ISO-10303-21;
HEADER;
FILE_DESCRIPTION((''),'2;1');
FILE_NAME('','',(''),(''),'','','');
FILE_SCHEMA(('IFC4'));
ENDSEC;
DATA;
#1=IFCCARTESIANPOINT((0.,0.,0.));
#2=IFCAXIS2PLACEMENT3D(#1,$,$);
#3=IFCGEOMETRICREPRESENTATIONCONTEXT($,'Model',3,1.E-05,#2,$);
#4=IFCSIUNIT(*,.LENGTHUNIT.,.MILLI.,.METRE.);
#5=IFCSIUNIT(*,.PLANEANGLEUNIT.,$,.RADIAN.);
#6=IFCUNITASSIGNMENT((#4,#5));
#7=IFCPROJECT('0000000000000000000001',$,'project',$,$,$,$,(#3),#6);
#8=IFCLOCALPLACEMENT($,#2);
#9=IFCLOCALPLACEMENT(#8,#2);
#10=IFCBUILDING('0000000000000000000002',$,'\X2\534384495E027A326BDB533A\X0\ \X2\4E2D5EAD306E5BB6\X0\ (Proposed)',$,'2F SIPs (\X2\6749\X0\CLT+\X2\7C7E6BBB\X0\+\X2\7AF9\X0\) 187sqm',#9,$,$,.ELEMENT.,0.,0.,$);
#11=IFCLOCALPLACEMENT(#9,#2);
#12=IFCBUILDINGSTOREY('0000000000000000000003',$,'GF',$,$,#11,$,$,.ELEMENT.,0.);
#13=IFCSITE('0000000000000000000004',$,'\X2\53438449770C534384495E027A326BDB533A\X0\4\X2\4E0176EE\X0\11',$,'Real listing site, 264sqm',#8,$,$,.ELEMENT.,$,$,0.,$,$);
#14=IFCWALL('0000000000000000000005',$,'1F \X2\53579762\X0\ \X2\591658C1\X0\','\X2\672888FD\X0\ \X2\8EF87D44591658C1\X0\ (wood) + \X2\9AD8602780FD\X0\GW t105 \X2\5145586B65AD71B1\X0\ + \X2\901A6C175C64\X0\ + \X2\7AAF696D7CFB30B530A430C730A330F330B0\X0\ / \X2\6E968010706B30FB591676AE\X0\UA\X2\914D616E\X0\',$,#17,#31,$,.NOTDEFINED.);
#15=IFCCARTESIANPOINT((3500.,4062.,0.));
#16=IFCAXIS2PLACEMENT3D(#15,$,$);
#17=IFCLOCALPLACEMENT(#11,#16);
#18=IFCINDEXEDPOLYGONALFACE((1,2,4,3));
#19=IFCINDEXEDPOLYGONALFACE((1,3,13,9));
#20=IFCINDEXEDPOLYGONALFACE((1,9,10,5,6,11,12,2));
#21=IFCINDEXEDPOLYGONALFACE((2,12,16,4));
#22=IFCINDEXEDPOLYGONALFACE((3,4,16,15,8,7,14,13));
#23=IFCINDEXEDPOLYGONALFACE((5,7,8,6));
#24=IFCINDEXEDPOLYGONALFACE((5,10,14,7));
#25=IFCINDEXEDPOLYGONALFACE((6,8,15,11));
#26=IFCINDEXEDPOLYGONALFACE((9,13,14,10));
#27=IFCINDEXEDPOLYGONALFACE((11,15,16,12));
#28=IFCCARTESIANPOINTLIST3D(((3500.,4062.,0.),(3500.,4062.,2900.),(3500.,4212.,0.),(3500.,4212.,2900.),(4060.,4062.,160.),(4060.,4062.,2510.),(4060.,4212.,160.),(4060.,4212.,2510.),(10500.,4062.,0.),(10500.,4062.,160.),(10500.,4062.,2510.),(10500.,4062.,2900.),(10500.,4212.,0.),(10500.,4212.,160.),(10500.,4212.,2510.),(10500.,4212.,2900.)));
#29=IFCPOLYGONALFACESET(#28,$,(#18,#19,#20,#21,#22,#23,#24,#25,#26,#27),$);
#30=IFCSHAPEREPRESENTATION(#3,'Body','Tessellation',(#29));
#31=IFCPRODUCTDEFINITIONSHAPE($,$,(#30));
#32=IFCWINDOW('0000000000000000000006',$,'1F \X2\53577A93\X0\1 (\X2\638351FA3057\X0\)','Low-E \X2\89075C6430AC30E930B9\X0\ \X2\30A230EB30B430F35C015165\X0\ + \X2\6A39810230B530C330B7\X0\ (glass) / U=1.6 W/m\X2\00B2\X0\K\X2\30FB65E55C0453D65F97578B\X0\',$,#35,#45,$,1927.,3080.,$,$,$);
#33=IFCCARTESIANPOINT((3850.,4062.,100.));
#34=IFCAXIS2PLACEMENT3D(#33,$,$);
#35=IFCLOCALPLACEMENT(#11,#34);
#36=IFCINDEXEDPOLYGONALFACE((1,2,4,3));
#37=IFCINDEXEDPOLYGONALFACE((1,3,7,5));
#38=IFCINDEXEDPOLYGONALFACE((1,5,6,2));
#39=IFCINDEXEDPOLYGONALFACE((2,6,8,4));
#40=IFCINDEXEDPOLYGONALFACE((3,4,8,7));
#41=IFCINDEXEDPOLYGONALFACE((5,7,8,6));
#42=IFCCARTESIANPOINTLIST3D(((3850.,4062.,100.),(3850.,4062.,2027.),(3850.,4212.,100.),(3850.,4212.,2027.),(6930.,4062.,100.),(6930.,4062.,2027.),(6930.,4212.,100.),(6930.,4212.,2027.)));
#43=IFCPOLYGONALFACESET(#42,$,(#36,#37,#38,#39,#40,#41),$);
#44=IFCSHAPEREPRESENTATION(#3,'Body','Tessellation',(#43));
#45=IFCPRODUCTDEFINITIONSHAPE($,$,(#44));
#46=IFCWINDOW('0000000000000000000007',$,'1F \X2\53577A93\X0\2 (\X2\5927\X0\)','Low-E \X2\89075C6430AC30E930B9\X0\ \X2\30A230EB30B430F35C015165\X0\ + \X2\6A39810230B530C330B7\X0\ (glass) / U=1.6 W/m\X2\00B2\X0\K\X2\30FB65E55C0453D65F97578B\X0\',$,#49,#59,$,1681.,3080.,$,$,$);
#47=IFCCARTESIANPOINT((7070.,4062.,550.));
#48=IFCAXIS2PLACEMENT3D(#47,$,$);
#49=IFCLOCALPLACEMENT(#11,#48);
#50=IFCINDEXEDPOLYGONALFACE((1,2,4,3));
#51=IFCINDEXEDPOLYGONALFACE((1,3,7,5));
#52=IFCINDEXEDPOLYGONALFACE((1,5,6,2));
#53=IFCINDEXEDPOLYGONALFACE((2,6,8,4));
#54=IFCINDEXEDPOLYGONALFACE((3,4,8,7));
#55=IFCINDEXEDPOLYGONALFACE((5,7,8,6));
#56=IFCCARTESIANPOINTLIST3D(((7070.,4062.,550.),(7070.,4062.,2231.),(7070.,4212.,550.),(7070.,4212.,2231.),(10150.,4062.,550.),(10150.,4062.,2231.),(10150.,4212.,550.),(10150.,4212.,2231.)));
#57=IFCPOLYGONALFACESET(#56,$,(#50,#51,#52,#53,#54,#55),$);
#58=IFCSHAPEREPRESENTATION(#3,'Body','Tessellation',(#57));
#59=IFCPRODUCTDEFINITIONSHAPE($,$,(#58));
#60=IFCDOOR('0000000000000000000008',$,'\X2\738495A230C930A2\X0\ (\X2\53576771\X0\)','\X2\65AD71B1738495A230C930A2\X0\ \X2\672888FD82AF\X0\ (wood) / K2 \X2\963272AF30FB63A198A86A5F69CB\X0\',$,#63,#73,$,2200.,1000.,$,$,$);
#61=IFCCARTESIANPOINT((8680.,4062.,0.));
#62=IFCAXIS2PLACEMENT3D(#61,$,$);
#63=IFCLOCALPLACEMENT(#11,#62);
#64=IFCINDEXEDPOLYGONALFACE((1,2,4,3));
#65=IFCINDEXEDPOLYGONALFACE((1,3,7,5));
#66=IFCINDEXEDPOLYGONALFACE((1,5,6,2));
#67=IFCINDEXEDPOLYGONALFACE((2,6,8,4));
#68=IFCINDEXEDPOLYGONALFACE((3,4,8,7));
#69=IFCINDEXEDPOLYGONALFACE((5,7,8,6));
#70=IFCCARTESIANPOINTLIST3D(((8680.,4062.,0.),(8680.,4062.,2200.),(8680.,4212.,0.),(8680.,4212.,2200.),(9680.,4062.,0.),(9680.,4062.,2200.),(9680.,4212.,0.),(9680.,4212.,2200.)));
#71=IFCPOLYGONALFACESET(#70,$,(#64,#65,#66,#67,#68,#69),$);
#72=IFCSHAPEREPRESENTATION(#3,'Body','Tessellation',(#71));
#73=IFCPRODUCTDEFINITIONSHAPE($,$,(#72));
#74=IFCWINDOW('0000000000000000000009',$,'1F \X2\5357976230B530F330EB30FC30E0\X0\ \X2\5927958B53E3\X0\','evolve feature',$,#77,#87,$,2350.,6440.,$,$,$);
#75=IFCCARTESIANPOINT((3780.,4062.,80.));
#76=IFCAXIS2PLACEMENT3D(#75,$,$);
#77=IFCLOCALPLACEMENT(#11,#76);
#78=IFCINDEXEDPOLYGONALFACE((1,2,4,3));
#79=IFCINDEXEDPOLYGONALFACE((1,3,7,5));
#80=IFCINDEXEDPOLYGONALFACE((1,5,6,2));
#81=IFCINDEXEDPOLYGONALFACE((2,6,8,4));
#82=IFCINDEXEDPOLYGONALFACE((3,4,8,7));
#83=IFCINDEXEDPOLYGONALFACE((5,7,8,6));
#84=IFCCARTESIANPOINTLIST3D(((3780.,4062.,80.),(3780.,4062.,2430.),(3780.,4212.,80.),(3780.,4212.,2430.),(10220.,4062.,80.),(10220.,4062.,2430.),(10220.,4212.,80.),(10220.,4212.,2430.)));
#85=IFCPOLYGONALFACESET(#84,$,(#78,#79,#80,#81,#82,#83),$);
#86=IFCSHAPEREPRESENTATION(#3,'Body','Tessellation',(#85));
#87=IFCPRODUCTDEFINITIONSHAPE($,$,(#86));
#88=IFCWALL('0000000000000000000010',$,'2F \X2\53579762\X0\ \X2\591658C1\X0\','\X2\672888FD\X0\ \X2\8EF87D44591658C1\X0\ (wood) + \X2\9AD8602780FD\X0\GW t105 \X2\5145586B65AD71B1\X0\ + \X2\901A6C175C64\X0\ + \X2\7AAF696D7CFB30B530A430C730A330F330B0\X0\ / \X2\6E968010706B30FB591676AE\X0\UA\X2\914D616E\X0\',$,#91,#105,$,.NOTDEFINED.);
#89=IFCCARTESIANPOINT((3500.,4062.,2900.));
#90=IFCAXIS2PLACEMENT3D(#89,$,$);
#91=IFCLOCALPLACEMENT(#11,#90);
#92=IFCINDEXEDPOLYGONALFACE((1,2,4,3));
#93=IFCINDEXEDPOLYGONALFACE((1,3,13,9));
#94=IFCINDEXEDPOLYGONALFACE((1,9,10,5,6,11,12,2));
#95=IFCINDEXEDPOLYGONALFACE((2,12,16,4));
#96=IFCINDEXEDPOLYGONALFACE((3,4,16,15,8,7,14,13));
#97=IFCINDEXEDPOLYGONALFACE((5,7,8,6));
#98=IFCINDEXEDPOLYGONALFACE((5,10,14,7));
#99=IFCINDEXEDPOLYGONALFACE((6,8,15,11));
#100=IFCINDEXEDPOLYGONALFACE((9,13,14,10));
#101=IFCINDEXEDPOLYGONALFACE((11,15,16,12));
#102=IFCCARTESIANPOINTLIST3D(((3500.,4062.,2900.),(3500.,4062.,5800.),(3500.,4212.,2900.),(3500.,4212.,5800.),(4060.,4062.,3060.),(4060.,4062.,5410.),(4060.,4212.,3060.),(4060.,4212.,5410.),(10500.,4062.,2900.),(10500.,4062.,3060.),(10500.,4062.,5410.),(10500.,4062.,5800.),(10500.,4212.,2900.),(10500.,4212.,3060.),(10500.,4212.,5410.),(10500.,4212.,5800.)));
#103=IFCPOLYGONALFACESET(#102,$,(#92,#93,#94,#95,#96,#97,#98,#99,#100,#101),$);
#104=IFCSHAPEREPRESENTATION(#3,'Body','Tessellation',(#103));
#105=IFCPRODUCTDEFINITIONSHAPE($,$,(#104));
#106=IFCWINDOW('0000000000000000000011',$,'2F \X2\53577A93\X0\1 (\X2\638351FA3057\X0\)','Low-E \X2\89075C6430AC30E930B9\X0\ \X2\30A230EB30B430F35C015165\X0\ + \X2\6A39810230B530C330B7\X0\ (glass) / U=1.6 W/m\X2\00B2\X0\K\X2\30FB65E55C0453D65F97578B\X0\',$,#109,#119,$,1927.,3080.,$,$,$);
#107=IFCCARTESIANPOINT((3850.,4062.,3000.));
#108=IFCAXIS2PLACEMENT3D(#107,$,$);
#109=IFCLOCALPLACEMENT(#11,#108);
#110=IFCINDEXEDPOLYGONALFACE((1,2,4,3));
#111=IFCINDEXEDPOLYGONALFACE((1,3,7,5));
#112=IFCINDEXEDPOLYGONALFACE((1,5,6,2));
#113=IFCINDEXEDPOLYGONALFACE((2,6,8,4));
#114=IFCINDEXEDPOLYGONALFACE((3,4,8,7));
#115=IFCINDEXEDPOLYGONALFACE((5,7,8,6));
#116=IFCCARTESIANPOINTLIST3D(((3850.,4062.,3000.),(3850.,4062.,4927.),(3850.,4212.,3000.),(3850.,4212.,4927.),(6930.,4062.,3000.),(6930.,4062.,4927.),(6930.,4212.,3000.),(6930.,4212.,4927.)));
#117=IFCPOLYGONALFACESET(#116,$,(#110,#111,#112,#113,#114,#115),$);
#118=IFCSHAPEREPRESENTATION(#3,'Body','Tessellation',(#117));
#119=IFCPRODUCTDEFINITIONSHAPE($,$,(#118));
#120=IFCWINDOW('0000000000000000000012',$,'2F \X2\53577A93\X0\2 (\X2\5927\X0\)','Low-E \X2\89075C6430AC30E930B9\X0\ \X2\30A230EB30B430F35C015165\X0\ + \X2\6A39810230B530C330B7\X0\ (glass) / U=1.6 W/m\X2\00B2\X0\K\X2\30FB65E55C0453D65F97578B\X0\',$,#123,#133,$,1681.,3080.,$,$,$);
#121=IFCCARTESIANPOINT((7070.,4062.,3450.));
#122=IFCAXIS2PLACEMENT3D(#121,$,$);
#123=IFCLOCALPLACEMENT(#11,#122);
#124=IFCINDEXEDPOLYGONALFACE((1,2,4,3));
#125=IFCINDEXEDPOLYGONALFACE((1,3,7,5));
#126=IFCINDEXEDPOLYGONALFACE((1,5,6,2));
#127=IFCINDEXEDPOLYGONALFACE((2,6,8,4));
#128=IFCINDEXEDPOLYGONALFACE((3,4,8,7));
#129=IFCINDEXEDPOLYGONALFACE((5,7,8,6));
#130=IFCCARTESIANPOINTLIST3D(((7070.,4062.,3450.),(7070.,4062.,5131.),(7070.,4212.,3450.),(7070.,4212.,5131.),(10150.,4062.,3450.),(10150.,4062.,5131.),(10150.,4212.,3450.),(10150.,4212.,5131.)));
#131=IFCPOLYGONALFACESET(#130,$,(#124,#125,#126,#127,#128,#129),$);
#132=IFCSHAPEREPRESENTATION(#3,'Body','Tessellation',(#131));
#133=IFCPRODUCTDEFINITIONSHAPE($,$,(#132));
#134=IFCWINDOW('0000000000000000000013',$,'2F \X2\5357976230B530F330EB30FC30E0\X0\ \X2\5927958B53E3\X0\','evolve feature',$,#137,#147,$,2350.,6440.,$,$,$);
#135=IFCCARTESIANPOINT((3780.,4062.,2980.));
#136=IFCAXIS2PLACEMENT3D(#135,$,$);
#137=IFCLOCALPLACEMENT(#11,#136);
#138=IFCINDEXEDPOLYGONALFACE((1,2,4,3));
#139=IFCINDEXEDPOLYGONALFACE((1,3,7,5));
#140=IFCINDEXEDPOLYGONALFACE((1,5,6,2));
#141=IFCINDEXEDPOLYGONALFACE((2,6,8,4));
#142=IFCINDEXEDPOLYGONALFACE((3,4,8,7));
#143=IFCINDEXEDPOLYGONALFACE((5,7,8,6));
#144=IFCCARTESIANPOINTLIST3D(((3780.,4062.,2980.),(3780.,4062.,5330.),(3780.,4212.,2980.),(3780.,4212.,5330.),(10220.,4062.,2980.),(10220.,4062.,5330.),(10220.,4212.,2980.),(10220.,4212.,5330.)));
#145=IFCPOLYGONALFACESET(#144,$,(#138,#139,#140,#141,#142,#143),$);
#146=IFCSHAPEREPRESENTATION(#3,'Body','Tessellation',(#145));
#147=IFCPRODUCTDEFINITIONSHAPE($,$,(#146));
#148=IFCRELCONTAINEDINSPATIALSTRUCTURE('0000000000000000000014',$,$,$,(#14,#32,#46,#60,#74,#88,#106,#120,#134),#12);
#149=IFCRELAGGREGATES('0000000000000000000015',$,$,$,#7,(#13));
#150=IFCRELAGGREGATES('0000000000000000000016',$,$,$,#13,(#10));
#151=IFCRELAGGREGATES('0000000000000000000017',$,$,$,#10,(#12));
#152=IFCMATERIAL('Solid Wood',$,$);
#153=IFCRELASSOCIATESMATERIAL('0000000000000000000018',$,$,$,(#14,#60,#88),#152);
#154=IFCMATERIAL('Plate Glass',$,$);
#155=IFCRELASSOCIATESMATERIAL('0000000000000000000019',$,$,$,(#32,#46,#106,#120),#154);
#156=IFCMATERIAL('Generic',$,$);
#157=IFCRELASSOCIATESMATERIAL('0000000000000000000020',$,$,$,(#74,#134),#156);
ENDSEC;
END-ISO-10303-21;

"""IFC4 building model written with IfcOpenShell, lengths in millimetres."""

from ifc_helpers import new_model, si_unit, frame, frame_2d, origin, place, context, project, spatial, rectangle, extrude, material, element, fill, save


model = new_model("IFC4")

# Units and contexts
model_context = context("Model", 3, precision=1e-05, world=origin())
ifc_project = project(units=[si_unit("LENGTHUNIT", "METRE", prefix="MILLI"), si_unit("PLANEANGLEUNIT", "RADIAN")], contexts=[model_context])

# Site, building, storey
site_placement = place(None, origin())
site = spatial("IfcSite", under=ifc_project, at=site_placement, Name="千葉県千葉市稲毛区4丁目11", ObjectType="Real listing site, 264sqm", CompositionType="ELEMENT", RefElevation=0.0)
building_placement = place(site_placement, origin())
building = spatial("IfcBuilding", under=site, at=building_placement, Name="千葉市稲毛区 中庭の家 (Proposed)", ObjectType="2F SIPs (杉CLT+籾殻+竹) 187sqm", CompositionType="ELEMENT", ElevationOfRefHeight=0.0, ElevationOfTerrain=0.0)
storey_placement = place(building_placement, origin())
storey = spatial("IfcBuildingStorey", under=building, at=storey_placement, Name="GF", CompositionType="ELEMENT", Elevation=0.0)

# Shared definitions
ifc_material_1 = material(Name="Solid Wood")
ifc_material_2 = material(Name="Generic")

# Wall, openings, windows, door
wall_1_placement = place(storey_placement, frame((3500.0, 4062.0, 0.0)))
wall_1 = element("IfcWall", 1, at=wall_1_placement, inside=storey, material=ifc_material_1, Name="1F 南面 外壁", Description="木製 軸組外壁 (wood) + 高性能GW t105 充填断熱 + 通気層 + 窯業系サイディング / 準耐火・外皮UA配慮", PredefinedType="NOTDEFINED", context=model_context, shape_type="SweptSolid", body=[
    extrude(rectangle(XDim=7000.0, YDim=150.0, at=frame_2d((3500.0, 75.0))), frame((3500.0, 4062.0, 0.0)), (0.0, 0.0, 1.0), 2900.0),
])
opening_1_placement = place(storey_placement, frame((3850.0, 4062.0, 100.0)))
opening_1 = element("IfcOpeningElement", 2, at=opening_1_placement, cuts=wall_1, PredefinedType="NOTDEFINED", context=model_context, shape_type="SweptSolid", body=[
    extrude(rectangle(XDim=3080.0, YDim=150.0, at=frame_2d((1540.0, 75.0))), frame((3850.0, 4062.0, 100.0)), (0.0, 0.0, 1.0), 1927.0),
])
opening_2_placement = place(storey_placement, frame((7070.0, 4062.0, 550.0)))
opening_2 = element("IfcOpeningElement", 3, at=opening_2_placement, cuts=wall_1, PredefinedType="NOTDEFINED", context=model_context, shape_type="SweptSolid", body=[
    extrude(rectangle(XDim=3080.0, YDim=150.0, at=frame_2d((1540.0, 75.0))), frame((7070.0, 4062.0, 550.0)), (0.0, 0.0, 1.0), 1681.0),
])
opening_3_placement = place(storey_placement, frame((8680.0, 4062.0, 0.0)))
opening_3 = element("IfcOpeningElement", 4, at=opening_3_placement, cuts=wall_1, PredefinedType="NOTDEFINED", context=model_context, shape_type="SweptSolid", body=[
    extrude(rectangle(XDim=1000.0, YDim=150.0, at=frame_2d((500.0, 75.0))), frame((8680.0, 4062.0, 0.0)), (0.0, 0.0, 1.0), 2200.0),
])
opening_4_placement = place(storey_placement, frame((3780.0, 4062.0, 80.0)))
opening_4 = element("IfcOpeningElement", 5, at=opening_4_placement, cuts=wall_1, PredefinedType="NOTDEFINED", context=model_context, shape_type="SweptSolid", body=[
    extrude(rectangle(XDim=6440.0, YDim=150.0, at=frame_2d((3220.0, 75.0))), frame((3780.0, 4062.0, 80.0)), (0.0, 0.0, 1.0), 2350.0),
])
ifc_material_3 = material(Name="Plate Glass")
window_1_placement = place(storey_placement, frame((3850.0, 4062.0, 100.0)))
window_1 = element("IfcWindow", 6, at=window_1_placement, inside=storey, material=ifc_material_3, Name="1F 南窓1 (掃出し)", Description="Low-E 複層ガラス アルゴン封入 + 樹脂サッシ (glass) / U=1.6 W/m²K・日射取得型", OverallHeight=1927.0, OverallWidth=3080.0, context=model_context, shape_type="SweptSolid", body=[
    extrude(rectangle(XDim=3080.0, YDim=150.0, at=frame_2d((1540.0, 75.0))), frame((3850.0, 4062.0, 100.0)), (0.0, 0.0, 1.0), 1927.0),
])
fill(opening_1, window_1)
window_2_placement = place(storey_placement, frame((7070.0, 4062.0, 550.0)))
window_2 = element("IfcWindow", 7, at=window_2_placement, inside=storey, material=ifc_material_3, Name="1F 南窓2 (大)", Description="Low-E 複層ガラス アルゴン封入 + 樹脂サッシ (glass) / U=1.6 W/m²K・日射取得型", OverallHeight=1681.0, OverallWidth=3080.0, context=model_context, shape_type="SweptSolid", body=[
    extrude(rectangle(XDim=3080.0, YDim=150.0, at=frame_2d((1540.0, 75.0))), frame((7070.0, 4062.0, 550.0)), (0.0, 0.0, 1.0), 1681.0),
])
fill(opening_2, window_2)
door_placement = place(storey_placement, frame((8680.0, 4062.0, 0.0)))
door = element("IfcDoor", 8, at=door_placement, inside=storey, material=ifc_material_1, Name="玄関ドア (南東)", Description="断熱玄関ドア 木製芯 (wood) / K2 防犯・採風機構", OverallHeight=2200.0, OverallWidth=1000.0, context=model_context, shape_type="SweptSolid", body=[
    extrude(rectangle(XDim=1000.0, YDim=150.0, at=frame_2d((500.0, 75.0))), frame((8680.0, 4062.0, 0.0)), (0.0, 0.0, 1.0), 2200.0),
])
fill(opening_3, door)
window_3_placement = place(storey_placement, frame((3780.0, 4062.0, 80.0)))
window_3 = element("IfcWindow", 9, at=window_3_placement, inside=storey, material=ifc_material_2, Name="1F 南面サンルーム 大開口", Description="evolve feature", OverallHeight=2350.0, OverallWidth=6440.0, context=model_context, shape_type="SweptSolid", body=[
    extrude(rectangle(XDim=6440.0, YDim=150.0, at=frame_2d((3220.0, 75.0))), frame((3780.0, 4062.0, 80.0)), (0.0, 0.0, 1.0), 2350.0),
])
fill(opening_4, window_3)

# Wall, openings, windows
wall_2_placement = place(storey_placement, frame((3500.0, 4062.0, 2900.0)))
wall_2 = element("IfcWall", 10, at=wall_2_placement, inside=storey, material=ifc_material_1, Name="2F 南面 外壁", Description="木製 軸組外壁 (wood) + 高性能GW t105 充填断熱 + 通気層 + 窯業系サイディング / 準耐火・外皮UA配慮", PredefinedType="NOTDEFINED", context=model_context, shape_type="SweptSolid", body=[
    extrude(rectangle(XDim=7000.0, YDim=150.0, at=frame_2d((3500.0, 75.0))), frame((3500.0, 4062.0, 2900.0)), (0.0, 0.0, 1.0), 2900.0),
])
opening_5_placement = place(storey_placement, frame((3850.0, 4062.0, 3000.0)))
opening_5 = element("IfcOpeningElement", 11, at=opening_5_placement, cuts=wall_2, PredefinedType="NOTDEFINED", context=model_context, shape_type="SweptSolid", body=[
    extrude(rectangle(XDim=3080.0, YDim=150.0, at=frame_2d((1540.0, 75.0))), frame((3850.0, 4062.0, 3000.0)), (0.0, 0.0, 1.0), 1927.0),
])
opening_6_placement = place(storey_placement, frame((7070.0, 4062.0, 3450.0)))
opening_6 = element("IfcOpeningElement", 12, at=opening_6_placement, cuts=wall_2, PredefinedType="NOTDEFINED", context=model_context, shape_type="SweptSolid", body=[
    extrude(rectangle(XDim=3080.0, YDim=150.0, at=frame_2d((1540.0, 75.0))), frame((7070.0, 4062.0, 3450.0)), (0.0, 0.0, 1.0), 1681.0),
])
opening_7_placement = place(storey_placement, frame((3780.0, 4062.0, 2980.0)))
opening_7 = element("IfcOpeningElement", 13, at=opening_7_placement, cuts=wall_2, PredefinedType="NOTDEFINED", context=model_context, shape_type="SweptSolid", body=[
    extrude(rectangle(XDim=6440.0, YDim=150.0, at=frame_2d((3220.0, 75.0))), frame((3780.0, 4062.0, 2980.0)), (0.0, 0.0, 1.0), 2350.0),
])
window_4_placement = place(storey_placement, frame((3850.0, 4062.0, 3000.0)))
window_4 = element("IfcWindow", 14, at=window_4_placement, inside=storey, material=ifc_material_3, Name="2F 南窓1 (掃出し)", Description="Low-E 複層ガラス アルゴン封入 + 樹脂サッシ (glass) / U=1.6 W/m²K・日射取得型", OverallHeight=1927.0, OverallWidth=3080.0, context=model_context, shape_type="SweptSolid", body=[
    extrude(rectangle(XDim=3080.0, YDim=150.0, at=frame_2d((1540.0, 75.0))), frame((3850.0, 4062.0, 3000.0)), (0.0, 0.0, 1.0), 1927.0),
])
fill(opening_5, window_4)
window_5_placement = place(storey_placement, frame((7070.0, 4062.0, 3450.0)))
window_5 = element("IfcWindow", 15, at=window_5_placement, inside=storey, material=ifc_material_3, Name="2F 南窓2 (大)", Description="Low-E 複層ガラス アルゴン封入 + 樹脂サッシ (glass) / U=1.6 W/m²K・日射取得型", OverallHeight=1681.0, OverallWidth=3080.0, context=model_context, shape_type="SweptSolid", body=[
    extrude(rectangle(XDim=3080.0, YDim=150.0, at=frame_2d((1540.0, 75.0))), frame((7070.0, 4062.0, 3450.0)), (0.0, 0.0, 1.0), 1681.0),
])
fill(opening_6, window_5)
window_6_placement = place(storey_placement, frame((3780.0, 4062.0, 2980.0)))
window_6 = element("IfcWindow", 16, at=window_6_placement, inside=storey, material=ifc_material_2, Name="2F 南面サンルーム 大開口", Description="evolve feature", OverallHeight=2350.0, OverallWidth=6440.0, context=model_context, shape_type="SweptSolid", body=[
    extrude(rectangle(XDim=6440.0, YDim=150.0, at=frame_2d((3220.0, 75.0))), frame((3780.0, 4062.0, 2980.0)), (0.0, 0.0, 1.0), 2350.0),
])
fill(opening_7, window_6)

save(model, "model.ifc")
